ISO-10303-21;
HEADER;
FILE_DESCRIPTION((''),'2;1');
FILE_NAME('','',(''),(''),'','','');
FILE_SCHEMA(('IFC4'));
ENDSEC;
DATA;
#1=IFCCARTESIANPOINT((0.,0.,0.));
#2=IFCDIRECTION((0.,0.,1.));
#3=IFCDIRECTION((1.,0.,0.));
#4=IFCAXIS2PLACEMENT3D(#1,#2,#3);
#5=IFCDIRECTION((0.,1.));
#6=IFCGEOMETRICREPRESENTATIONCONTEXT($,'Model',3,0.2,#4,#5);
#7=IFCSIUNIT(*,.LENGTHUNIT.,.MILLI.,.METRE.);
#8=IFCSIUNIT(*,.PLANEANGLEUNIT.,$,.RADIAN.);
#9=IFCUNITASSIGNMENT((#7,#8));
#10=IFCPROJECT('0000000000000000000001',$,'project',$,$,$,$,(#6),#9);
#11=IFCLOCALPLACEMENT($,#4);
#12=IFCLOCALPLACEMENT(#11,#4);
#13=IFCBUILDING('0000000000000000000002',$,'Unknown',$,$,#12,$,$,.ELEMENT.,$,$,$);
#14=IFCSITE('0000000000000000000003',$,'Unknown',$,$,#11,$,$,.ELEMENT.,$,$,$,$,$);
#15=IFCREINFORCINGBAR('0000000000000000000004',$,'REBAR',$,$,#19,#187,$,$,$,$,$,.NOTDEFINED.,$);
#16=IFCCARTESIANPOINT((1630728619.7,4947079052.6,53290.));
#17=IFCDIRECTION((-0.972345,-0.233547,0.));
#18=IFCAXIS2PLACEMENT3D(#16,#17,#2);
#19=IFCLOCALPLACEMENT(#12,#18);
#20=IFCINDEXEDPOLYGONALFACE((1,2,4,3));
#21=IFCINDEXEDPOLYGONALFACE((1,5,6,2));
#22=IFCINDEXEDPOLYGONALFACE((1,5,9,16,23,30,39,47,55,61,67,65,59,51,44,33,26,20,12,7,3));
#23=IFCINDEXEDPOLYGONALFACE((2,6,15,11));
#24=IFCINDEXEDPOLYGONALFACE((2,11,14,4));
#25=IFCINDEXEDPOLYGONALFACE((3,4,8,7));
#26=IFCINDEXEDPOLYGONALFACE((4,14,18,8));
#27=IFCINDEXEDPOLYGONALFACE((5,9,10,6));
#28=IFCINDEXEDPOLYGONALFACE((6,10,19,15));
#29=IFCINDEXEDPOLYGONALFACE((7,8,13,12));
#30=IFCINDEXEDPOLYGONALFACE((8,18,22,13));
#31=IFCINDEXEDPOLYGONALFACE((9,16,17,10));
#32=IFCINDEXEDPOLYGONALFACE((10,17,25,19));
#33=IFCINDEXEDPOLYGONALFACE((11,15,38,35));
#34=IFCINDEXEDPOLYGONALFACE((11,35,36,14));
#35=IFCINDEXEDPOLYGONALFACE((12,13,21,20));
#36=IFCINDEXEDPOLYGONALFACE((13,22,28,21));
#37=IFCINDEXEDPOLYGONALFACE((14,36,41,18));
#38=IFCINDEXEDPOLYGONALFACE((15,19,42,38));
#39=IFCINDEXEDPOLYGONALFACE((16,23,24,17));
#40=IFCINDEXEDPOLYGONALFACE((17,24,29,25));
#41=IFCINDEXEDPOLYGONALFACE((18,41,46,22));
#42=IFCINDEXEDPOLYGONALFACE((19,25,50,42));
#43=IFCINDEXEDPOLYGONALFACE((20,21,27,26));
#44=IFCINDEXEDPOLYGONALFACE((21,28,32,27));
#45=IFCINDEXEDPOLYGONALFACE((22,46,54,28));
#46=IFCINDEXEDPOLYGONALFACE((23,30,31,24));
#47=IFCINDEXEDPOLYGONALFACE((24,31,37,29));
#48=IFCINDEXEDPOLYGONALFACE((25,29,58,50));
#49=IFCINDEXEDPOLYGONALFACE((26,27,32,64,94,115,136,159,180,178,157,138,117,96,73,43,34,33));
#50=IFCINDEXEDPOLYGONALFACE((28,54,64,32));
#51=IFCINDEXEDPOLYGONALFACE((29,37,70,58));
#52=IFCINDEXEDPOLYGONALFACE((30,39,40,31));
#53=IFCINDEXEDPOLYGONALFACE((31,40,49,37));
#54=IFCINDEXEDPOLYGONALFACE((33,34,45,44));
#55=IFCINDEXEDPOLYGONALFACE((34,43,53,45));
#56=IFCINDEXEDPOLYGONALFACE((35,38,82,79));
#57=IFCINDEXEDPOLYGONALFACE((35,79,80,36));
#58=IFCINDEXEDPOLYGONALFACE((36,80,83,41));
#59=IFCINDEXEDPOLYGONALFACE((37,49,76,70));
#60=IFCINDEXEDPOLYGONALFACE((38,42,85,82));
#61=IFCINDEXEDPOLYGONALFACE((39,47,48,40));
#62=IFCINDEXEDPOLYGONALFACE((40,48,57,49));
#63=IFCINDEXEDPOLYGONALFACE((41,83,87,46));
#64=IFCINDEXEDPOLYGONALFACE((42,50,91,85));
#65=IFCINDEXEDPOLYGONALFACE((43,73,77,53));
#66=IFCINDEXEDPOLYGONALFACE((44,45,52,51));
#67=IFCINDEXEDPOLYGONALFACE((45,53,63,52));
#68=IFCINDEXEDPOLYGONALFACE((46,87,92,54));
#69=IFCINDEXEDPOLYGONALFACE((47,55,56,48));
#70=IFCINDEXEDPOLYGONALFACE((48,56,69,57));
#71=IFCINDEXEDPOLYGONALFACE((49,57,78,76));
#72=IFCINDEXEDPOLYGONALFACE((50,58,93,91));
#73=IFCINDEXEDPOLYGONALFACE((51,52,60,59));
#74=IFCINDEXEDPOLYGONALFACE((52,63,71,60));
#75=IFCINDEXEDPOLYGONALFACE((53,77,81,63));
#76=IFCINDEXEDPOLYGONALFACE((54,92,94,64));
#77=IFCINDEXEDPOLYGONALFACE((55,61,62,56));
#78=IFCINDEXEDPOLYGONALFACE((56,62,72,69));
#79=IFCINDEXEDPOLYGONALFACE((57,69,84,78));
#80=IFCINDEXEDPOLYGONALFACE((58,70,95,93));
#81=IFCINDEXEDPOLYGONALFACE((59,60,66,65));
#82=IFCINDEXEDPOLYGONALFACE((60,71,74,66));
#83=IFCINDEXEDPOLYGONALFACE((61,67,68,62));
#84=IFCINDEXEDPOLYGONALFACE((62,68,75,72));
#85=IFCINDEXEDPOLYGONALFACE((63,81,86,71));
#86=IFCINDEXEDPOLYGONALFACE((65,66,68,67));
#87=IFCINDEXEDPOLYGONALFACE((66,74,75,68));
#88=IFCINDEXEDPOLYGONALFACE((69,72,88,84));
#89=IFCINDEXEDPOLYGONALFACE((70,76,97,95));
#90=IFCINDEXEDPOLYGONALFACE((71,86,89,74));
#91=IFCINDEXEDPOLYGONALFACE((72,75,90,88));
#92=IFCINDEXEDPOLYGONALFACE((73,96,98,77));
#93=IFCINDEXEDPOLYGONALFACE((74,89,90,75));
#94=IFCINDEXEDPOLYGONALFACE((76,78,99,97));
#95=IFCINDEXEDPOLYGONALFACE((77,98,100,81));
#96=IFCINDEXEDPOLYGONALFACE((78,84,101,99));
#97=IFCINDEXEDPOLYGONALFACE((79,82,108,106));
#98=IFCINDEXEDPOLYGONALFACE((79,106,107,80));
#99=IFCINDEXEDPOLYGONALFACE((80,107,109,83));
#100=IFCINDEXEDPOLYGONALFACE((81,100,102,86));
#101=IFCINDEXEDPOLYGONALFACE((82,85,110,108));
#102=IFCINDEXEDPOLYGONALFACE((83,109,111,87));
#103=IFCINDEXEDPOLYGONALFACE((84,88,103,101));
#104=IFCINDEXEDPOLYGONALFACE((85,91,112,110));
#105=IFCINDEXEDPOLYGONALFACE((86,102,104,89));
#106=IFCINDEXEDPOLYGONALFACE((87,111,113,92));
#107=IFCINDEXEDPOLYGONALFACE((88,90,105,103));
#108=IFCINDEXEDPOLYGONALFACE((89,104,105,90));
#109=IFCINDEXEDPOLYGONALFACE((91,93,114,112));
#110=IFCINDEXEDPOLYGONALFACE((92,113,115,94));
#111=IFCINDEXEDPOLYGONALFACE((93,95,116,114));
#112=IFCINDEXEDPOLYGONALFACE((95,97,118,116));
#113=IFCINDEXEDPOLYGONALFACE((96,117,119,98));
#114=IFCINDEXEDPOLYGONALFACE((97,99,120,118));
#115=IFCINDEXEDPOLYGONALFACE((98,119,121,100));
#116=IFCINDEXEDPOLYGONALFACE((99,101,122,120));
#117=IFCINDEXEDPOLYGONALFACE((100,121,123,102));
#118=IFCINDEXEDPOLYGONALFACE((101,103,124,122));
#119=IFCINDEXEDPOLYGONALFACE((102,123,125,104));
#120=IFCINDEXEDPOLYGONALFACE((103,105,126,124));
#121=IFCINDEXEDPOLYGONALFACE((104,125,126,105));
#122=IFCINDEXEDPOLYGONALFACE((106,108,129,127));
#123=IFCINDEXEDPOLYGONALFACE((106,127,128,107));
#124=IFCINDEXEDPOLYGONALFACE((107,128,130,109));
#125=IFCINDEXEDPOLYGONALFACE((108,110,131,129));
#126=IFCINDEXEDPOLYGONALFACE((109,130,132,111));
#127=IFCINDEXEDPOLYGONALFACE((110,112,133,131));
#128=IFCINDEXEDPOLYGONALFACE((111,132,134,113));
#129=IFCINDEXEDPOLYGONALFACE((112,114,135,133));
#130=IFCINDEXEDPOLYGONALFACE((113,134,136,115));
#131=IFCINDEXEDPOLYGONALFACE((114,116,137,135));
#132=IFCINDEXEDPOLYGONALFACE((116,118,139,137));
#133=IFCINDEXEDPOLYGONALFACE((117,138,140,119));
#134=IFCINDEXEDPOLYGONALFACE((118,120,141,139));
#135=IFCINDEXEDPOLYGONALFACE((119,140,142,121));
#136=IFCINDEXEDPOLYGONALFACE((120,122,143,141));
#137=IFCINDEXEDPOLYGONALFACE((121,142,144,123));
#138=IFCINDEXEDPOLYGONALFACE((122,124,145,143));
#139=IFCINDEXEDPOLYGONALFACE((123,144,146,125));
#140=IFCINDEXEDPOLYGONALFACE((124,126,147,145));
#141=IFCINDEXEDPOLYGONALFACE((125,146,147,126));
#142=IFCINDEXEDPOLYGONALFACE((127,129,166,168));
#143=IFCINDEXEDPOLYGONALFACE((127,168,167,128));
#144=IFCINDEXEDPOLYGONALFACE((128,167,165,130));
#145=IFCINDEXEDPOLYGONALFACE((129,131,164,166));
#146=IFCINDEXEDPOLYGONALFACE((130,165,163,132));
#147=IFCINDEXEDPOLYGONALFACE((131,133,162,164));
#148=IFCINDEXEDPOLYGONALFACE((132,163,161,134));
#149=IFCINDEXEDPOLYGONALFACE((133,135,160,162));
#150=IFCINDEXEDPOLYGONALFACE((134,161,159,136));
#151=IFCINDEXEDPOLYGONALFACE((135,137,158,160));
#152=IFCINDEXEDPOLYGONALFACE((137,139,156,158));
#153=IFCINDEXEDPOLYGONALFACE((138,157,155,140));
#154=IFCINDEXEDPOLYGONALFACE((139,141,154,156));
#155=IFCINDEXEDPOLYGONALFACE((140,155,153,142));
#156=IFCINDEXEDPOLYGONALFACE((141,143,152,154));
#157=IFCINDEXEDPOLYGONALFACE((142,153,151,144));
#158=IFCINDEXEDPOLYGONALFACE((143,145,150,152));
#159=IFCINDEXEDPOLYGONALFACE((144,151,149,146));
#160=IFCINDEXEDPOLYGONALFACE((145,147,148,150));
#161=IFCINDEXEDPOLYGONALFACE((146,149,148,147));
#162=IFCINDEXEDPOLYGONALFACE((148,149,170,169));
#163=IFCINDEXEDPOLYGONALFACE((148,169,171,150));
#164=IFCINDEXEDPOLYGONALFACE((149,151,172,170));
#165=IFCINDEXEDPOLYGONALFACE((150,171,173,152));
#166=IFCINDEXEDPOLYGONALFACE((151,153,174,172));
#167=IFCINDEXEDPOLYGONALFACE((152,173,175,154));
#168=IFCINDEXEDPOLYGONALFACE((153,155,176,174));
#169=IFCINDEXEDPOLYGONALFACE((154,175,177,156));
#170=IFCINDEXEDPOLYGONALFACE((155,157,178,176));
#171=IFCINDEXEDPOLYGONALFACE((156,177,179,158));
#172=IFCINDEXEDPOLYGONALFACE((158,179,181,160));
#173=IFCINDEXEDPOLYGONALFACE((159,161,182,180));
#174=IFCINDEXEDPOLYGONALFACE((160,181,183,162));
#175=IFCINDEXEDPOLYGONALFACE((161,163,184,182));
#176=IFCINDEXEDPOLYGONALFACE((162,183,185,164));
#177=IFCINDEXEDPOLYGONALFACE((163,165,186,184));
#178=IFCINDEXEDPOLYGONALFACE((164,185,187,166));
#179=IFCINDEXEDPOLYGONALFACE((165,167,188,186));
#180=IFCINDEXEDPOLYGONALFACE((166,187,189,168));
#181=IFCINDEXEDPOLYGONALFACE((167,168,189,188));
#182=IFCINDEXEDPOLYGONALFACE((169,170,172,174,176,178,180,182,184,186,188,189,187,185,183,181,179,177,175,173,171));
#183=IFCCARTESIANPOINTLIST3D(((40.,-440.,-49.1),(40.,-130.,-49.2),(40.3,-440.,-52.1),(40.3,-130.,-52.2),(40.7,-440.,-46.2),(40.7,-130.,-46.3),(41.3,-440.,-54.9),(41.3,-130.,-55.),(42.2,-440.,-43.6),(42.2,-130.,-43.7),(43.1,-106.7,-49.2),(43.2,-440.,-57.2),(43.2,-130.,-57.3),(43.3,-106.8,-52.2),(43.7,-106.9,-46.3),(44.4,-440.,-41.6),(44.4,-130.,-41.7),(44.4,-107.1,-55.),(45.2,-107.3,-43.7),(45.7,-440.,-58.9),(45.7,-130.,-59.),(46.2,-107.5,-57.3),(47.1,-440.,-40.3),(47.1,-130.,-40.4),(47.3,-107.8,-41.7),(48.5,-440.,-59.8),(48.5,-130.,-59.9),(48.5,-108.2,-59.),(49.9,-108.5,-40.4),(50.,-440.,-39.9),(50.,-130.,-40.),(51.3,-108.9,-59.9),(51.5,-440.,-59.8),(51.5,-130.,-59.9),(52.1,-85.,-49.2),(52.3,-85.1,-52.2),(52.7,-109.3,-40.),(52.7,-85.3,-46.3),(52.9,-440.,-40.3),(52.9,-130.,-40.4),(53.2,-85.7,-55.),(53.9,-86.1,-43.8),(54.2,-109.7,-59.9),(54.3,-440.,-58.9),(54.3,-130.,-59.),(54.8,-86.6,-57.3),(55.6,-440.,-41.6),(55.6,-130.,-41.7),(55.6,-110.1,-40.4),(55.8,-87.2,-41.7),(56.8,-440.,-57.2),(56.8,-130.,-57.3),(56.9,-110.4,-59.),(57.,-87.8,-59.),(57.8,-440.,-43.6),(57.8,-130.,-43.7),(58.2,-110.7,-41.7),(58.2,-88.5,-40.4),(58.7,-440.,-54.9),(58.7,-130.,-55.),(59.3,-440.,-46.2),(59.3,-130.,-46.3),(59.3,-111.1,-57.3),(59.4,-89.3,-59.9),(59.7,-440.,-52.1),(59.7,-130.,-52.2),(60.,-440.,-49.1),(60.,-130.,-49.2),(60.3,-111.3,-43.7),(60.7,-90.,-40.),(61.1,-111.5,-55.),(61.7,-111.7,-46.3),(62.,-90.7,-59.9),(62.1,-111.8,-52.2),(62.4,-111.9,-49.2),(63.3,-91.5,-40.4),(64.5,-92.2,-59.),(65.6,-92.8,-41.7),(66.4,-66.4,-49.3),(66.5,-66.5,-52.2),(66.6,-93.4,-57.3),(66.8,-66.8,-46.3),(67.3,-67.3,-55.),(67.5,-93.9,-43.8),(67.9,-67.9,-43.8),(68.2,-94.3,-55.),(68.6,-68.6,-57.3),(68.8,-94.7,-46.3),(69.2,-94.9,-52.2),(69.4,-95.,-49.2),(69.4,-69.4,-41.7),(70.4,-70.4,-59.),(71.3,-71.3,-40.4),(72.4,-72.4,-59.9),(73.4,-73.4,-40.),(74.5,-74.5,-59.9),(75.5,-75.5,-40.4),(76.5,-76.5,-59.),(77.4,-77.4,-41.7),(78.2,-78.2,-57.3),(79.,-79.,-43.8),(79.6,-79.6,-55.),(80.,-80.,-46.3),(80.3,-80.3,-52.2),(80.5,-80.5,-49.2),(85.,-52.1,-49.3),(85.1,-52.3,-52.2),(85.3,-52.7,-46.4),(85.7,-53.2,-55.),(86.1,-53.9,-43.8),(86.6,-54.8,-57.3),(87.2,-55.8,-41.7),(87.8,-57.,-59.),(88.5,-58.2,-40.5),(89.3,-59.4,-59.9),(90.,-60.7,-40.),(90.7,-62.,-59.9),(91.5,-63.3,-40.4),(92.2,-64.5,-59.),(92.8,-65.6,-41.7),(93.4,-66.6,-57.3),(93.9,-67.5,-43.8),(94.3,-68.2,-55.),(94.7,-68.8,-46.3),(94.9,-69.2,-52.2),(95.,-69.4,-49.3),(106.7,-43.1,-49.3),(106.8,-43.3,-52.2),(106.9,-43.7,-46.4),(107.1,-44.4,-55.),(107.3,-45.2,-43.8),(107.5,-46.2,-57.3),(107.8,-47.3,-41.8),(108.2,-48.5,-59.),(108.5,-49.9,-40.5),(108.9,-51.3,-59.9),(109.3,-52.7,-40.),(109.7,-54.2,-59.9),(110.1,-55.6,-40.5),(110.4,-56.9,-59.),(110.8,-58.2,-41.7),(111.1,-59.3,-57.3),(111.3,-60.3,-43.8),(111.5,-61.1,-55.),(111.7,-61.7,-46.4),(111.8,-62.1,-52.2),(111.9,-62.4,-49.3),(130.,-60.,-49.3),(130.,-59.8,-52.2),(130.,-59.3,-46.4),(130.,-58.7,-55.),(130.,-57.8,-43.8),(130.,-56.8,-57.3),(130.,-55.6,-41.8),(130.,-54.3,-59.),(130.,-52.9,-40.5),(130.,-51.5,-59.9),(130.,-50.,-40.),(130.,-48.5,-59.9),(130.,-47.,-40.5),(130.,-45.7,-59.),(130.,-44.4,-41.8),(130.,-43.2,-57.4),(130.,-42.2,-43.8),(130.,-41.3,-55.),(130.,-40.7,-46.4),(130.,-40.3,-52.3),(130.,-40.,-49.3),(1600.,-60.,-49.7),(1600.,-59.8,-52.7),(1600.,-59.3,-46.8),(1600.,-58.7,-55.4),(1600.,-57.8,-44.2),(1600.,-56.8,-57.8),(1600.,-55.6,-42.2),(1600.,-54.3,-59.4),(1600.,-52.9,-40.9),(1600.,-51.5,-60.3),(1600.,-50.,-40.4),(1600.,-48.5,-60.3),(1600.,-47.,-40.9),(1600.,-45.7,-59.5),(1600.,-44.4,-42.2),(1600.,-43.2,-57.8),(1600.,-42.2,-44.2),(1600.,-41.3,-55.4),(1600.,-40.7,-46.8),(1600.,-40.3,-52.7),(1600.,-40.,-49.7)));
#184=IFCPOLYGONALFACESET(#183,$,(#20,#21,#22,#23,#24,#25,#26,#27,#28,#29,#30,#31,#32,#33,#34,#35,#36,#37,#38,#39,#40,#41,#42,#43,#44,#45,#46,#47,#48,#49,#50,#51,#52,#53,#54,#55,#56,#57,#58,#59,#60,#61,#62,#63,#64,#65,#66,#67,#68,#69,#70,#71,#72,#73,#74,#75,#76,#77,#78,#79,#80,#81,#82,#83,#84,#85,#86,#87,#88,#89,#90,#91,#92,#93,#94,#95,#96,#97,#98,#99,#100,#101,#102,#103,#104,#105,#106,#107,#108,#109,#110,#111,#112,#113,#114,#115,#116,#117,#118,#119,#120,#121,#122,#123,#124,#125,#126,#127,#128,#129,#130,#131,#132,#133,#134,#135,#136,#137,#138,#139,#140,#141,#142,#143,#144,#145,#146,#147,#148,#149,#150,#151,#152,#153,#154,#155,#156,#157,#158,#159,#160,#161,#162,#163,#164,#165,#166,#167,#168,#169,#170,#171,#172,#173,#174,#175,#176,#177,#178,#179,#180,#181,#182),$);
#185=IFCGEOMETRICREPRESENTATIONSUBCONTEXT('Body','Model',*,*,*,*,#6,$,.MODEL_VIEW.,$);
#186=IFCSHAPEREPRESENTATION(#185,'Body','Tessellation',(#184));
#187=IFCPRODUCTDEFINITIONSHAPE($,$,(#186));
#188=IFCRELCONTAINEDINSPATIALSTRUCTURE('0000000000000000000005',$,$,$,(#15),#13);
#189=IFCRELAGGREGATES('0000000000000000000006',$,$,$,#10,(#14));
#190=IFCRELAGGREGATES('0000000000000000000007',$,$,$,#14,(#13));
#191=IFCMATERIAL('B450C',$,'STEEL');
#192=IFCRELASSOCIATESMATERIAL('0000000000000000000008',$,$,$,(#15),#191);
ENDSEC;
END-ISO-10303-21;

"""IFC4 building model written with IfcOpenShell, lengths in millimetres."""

from ifc_helpers import new_model, entity, si_unit, direction, frame, origin_with_axes, place, context, subcontext, project, spatial, material, element, save


model = new_model("IFC4")

# Units and contexts
model_context = context("Model", 3, precision=0.2, world=origin_with_axes(), true_north=direction((0.0, 1.0)))
body_context = subcontext(model_context, "Body", "Model", "MODEL_VIEW")
ifc_project = project(units=[si_unit("LENGTHUNIT", "METRE", prefix="MILLI"), si_unit("PLANEANGLEUNIT", "RADIAN")], contexts=[model_context])

# Site, building
site_placement = place(None, origin_with_axes())
site = spatial("IfcSite", under=ifc_project, at=site_placement, Name="Unknown", CompositionType="ELEMENT")
building_placement = place(site_placement, origin_with_axes())
building = spatial("IfcBuilding", under=site, at=building_placement, Name="Unknown", CompositionType="ELEMENT")

# Reinforcing bar
ifc_material = material(Name="B450C", Category="STEEL")
reinforcing_bar_1_placement = place(building_placement, frame((1630728619.7, 4947079052.6, 53290.0), z_axis=(-0.972345, -0.233547, 0.0), x_axis=(0.0, 0.0, 1.0)))
element("IfcReinforcingBar", 1, at=reinforcing_bar_1_placement, inside=building, material=ifc_material, Name="REBAR", PredefinedType="NOTDEFINED", context=body_context, shape_type="AdvancedSweptSolid", body=[
    entity("IfcSweptDiskSolid", entity("IfcIndexedPolyCurve", entity("IfcCartesianPointList3D", [[50.0, -440.0, -49.9], [50.0, -130.0, -50.0], [73.4, -73.4, -50.0], [130.0, -50.0, -50.0], [1600.0, -50.0, -50.4]]), [entity("IfcLineIndex", [1, 2]), entity("IfcArcIndex", [2, 3, 4]), entity("IfcLineIndex", [4, 5])]), 10.0),
])

save(model, "model.ifc")
